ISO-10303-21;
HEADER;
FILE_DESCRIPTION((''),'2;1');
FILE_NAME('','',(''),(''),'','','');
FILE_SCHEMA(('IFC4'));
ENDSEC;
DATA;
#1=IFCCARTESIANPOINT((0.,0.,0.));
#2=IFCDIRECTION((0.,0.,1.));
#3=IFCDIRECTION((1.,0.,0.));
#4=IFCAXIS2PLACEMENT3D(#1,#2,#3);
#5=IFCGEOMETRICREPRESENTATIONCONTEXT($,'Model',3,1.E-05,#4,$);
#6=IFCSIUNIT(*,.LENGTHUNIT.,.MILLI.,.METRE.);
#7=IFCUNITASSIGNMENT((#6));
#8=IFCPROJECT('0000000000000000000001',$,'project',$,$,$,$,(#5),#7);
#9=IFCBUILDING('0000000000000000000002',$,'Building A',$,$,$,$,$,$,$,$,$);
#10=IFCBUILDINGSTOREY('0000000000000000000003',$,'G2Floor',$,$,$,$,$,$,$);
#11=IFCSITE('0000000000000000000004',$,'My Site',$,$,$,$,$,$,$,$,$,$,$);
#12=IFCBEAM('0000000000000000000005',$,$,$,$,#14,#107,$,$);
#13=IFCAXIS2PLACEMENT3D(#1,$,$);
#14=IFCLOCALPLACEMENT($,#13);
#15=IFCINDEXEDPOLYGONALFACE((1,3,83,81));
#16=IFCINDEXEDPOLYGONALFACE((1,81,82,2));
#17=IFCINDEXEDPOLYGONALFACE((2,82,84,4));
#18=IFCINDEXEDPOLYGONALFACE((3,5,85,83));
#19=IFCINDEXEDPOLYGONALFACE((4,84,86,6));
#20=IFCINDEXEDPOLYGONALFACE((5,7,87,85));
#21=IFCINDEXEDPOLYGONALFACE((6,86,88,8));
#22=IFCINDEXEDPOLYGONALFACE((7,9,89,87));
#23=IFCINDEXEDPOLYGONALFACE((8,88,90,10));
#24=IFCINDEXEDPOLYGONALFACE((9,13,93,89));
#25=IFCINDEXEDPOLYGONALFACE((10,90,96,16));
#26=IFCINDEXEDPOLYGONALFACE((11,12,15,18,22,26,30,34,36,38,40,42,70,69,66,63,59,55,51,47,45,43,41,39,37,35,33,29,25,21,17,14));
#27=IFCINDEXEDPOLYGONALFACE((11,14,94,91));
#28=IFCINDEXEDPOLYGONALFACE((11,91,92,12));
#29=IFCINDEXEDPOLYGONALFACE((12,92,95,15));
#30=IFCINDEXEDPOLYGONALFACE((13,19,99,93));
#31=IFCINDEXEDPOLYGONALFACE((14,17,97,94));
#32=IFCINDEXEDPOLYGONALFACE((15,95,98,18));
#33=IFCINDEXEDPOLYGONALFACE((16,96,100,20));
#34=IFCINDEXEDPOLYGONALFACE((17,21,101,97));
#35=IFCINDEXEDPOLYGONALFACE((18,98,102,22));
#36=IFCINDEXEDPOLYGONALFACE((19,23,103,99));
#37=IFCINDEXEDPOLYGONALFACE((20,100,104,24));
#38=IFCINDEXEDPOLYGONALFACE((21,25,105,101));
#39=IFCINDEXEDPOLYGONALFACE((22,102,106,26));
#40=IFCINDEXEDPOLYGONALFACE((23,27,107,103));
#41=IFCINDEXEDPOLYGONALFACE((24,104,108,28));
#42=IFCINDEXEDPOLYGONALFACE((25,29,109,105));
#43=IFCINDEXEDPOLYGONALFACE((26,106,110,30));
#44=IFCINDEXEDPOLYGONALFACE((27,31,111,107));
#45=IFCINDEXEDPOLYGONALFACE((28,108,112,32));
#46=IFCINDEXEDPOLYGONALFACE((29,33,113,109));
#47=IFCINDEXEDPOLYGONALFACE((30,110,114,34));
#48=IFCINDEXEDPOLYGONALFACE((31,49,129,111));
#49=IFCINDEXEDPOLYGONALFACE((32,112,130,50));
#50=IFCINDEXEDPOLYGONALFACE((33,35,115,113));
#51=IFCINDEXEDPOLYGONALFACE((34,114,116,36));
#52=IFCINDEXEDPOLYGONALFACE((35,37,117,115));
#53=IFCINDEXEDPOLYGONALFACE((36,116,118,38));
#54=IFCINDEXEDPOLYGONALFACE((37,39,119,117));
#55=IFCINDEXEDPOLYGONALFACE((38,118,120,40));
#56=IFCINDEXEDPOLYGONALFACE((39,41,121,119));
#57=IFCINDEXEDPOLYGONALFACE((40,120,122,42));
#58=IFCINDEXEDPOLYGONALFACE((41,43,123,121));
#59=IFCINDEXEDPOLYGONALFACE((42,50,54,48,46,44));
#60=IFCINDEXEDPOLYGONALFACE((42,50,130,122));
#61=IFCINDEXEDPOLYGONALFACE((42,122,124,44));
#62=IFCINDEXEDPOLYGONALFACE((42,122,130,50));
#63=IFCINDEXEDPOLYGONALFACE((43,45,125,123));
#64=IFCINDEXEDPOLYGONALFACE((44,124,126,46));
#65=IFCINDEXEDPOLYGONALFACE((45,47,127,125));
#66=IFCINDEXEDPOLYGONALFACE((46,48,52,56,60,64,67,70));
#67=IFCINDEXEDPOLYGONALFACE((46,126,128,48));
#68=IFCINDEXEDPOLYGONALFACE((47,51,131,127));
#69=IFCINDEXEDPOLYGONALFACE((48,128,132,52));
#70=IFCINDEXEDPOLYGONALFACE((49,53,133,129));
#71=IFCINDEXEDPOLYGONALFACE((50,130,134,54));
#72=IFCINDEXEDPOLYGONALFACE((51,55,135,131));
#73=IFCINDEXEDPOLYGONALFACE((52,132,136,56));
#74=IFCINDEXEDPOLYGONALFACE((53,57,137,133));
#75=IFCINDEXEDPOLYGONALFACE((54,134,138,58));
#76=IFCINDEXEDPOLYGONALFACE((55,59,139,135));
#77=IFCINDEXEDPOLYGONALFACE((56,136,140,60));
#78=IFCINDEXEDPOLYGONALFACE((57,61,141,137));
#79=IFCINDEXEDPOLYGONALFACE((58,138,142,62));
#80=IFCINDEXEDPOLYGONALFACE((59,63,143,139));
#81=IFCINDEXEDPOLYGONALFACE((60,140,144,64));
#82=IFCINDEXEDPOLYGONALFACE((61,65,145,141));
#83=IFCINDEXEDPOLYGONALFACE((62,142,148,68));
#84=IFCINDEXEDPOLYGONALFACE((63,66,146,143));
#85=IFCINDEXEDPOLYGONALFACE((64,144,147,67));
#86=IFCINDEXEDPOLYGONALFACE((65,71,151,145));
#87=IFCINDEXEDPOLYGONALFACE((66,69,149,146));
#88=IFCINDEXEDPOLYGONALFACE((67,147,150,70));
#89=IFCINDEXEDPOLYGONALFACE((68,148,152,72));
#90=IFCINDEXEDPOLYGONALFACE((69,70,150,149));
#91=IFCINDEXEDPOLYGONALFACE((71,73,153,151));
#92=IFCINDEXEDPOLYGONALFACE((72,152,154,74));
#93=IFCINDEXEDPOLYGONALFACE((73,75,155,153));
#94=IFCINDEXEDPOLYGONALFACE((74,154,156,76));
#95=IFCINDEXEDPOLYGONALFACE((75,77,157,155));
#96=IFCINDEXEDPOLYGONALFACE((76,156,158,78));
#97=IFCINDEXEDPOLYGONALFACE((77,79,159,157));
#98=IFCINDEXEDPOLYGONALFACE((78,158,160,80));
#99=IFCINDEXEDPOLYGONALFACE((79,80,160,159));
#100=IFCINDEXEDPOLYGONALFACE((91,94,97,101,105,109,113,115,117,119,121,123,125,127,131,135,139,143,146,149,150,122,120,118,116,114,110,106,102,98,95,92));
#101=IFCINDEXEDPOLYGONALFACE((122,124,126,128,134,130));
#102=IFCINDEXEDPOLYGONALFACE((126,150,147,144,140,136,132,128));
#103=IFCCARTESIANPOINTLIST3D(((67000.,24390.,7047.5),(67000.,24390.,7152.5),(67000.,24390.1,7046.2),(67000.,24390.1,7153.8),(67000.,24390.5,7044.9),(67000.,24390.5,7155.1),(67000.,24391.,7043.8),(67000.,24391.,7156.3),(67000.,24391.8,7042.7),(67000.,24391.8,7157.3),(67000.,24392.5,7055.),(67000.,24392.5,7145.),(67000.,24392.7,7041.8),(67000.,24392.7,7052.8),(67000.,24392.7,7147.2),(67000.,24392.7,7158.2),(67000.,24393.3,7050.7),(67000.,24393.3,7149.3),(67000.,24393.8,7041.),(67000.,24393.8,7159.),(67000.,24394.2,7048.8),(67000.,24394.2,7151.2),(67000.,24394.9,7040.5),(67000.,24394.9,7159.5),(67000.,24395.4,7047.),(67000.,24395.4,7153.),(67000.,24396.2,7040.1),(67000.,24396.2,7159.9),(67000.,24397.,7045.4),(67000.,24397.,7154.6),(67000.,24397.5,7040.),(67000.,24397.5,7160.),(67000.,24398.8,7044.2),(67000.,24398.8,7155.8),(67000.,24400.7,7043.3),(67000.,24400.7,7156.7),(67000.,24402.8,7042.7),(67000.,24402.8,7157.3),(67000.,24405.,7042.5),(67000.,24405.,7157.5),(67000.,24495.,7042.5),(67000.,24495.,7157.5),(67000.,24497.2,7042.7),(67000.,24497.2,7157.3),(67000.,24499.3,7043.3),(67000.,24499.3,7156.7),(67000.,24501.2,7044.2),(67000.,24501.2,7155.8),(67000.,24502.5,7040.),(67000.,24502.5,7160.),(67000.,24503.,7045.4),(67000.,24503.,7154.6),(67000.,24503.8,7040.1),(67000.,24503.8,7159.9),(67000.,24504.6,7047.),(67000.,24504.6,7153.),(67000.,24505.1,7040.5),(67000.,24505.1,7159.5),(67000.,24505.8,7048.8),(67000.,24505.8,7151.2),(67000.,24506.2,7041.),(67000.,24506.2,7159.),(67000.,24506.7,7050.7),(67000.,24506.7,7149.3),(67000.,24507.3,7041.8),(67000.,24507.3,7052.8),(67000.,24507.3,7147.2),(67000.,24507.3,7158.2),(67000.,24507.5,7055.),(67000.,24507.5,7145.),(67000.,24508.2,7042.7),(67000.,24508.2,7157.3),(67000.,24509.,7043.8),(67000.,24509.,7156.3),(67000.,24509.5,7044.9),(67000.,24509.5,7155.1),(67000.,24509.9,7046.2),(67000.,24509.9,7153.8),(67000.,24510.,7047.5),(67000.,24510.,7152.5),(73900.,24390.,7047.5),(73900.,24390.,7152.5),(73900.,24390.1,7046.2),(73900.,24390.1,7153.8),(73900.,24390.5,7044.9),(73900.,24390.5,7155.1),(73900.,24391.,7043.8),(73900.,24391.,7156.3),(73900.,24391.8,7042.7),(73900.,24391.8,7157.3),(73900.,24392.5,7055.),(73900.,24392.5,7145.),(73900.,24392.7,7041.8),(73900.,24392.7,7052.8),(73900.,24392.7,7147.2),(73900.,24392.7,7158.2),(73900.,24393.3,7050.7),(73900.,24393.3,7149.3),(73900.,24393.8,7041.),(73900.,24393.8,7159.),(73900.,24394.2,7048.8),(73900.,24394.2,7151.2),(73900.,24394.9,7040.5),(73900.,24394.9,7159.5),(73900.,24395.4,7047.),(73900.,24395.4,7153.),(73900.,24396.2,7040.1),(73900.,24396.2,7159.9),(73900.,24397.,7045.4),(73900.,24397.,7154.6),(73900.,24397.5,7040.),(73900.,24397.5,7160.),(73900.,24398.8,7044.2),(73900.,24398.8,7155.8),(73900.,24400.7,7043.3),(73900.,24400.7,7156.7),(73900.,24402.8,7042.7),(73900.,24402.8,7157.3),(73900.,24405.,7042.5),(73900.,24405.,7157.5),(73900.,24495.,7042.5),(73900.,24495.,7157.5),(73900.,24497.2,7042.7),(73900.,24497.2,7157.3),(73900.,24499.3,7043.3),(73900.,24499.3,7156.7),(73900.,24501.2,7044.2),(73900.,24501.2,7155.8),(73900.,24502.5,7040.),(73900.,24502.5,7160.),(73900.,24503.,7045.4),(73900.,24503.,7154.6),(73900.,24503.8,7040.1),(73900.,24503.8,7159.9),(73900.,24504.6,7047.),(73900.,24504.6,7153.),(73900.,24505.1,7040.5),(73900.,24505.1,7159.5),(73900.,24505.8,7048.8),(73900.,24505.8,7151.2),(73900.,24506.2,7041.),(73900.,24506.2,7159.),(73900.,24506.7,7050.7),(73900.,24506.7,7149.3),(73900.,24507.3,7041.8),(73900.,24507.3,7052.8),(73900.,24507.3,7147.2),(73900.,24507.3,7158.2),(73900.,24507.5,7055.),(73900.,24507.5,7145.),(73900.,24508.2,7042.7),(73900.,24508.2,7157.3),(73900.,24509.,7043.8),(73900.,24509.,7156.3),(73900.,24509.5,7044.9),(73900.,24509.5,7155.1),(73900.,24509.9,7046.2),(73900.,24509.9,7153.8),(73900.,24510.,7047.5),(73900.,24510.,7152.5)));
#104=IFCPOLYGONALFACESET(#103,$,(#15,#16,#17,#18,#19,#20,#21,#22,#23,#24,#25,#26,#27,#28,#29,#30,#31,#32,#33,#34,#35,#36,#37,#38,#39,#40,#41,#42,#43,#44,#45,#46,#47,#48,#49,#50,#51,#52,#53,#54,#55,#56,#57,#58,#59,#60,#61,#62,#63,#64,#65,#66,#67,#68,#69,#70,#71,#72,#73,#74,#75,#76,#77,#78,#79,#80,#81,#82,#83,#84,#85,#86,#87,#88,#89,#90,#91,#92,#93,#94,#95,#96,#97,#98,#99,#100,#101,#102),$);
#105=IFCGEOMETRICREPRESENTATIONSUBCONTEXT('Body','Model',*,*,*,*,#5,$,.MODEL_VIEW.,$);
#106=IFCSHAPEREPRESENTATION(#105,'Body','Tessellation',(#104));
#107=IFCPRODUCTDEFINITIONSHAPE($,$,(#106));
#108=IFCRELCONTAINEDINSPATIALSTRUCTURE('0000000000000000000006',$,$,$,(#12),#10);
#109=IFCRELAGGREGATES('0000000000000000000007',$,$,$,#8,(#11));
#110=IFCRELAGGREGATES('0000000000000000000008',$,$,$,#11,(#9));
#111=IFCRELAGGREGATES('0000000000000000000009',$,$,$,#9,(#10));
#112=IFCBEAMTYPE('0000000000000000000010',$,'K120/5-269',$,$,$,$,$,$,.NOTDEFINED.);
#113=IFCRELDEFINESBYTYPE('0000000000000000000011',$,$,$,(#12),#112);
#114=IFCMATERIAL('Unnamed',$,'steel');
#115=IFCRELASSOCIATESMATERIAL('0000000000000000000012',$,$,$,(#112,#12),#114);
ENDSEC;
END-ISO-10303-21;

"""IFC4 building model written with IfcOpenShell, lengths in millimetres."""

from ifc_helpers import new_model, si_unit, frame, origin_with_axes, place, context, subcontext, project, spatial, polyline, outline, extrude, material, material_profile, profile_set, profile_usage, type_object, element, save


model = new_model("IFC4")

# Units and contexts
model_context = context("Model", 3, precision=1e-05, world=origin_with_axes())
body_context = subcontext(model_context, "Body", "Model", "MODEL_VIEW")
ifc_project = project(units=[si_unit("LENGTHUNIT", "METRE", prefix="MILLI")], contexts=[model_context])

# Site, building, storey
site = spatial("IfcSite", under=ifc_project, Name="My Site")
building = spatial("IfcBuilding", under=site, Name="Building A")
storey = spatial("IfcBuildingStorey", under=building, Name="G2Floor")

# Beam
ifc_material_1 = material(Name="Unnamed", Category="steel")
ifc_material_profile_1 = material_profile(ifc_material_1, outline(polyline([(-52.5, -60.0), (52.5, -60.0), (52.5, -60.0), (53.8, -59.9), (53.8, -59.9), (55.1, -59.5), (55.1, -59.5), (56.2, -59.0), (56.2, -59.0), (57.3, -58.2), (57.3, -58.2), (58.2, -57.3), (58.2, -57.3), (59.0, -56.2), (59.0, -56.2), (59.5, -55.1), (59.5, -55.1), (59.9, -53.8), (59.9, -53.8), (60.0, -52.5), (60.0, -52.5), (60.0, 52.5), (60.0, 52.5), (59.9, 53.8), (59.9, 53.8), (59.5, 55.1), (59.5, 55.1), (59.0, 56.2), (59.0, 56.2), (58.2, 57.3), (58.2, 57.3), (57.3, 58.2), (57.3, 58.2), (56.2, 59.0), (56.2, 59.0), (55.1, 59.5), (55.1, 59.5), (53.8, 59.9), (53.8, 59.9), (52.5, 60.0), (52.5, 60.0), (-52.5, 60.0), (-52.5, 60.0), (-53.8, 59.9), (-53.8, 59.9), (-55.1, 59.5), (-55.1, 59.5), (-56.2, 59.0), (-56.2, 59.0), (-57.3, 58.2), (-57.3, 58.2), (-58.2, 57.3), (-58.2, 57.3), (-59.0, 56.2), (-59.0, 56.2), (-59.5, 55.1), (-59.5, 55.1), (-59.9, 53.8), (-59.9, 53.8), (-60.0, 52.5), (-60.0, 52.5), (-60.0, -52.5), (-60.0, -52.5), (-59.9, -53.8), (-59.9, -53.8), (-59.5, -55.1), (-59.5, -55.1), (-59.0, -56.2), (-59.0, -56.2), (-58.2, -57.3), (-58.2, -57.3), (-57.3, -58.2), (-57.3, -58.2), (-56.2, -59.0), (-56.2, -59.0), (-55.1, -59.5), (-55.1, -59.5), (-53.8, -59.9), (-53.8, -59.9), (-52.5, -60.0), (-52.5, -60.0), (-45.0, -57.5), (-45.0, -57.5), (45.0, -57.5), (45.0, -57.5), (47.2, -57.3), (47.2, -57.3), (49.3, -56.7), (49.3, -56.7), (51.2, -55.8), (51.2, -55.8), (53.0, -54.6), (53.0, -54.6), (54.6, -53.0), (54.6, -53.0), (55.8, -51.2), (55.8, -51.2), (56.7, -49.3), (56.7, -49.3), (57.3, -47.2), (57.3, -47.2), (57.5, -45.0), (57.5, -45.0), (57.5, 45.0), (57.5, 45.0), (57.3, 47.2), (57.3, 47.2), (56.7, 49.3), (56.7, 49.3), (55.8, 51.2), (55.8, 51.2), (54.6, 53.0), (54.6, 53.0), (53.0, 54.6), (53.0, 54.6), (51.2, 55.8), (51.2, 55.8), (49.3, 56.7), (49.3, 56.7), (47.2, 57.3), (47.2, 57.3), (45.0, 57.5), (45.0, 57.5), (-45.0, 57.5), (-45.0, 57.5), (-47.2, 57.3), (-47.2, 57.3), (-49.3, 56.7), (-49.3, 56.7), (-51.2, 55.8), (-51.2, 55.8), (-53.0, 54.6), (-53.0, 54.6), (-54.6, 53.0), (-54.6, 53.0), (-55.8, 51.2), (-55.8, 51.2), (-56.7, 49.3), (-56.7, 49.3), (-57.3, 47.2), (-57.3, 47.2), (-57.5, 45.0), (-57.5, 45.0), (-57.5, -45.0), (-57.5, -45.0), (-57.3, -47.2), (-57.3, -47.2), (-56.7, -49.3), (-56.7, -49.3), (-55.8, -51.2), (-55.8, -51.2), (-54.6, -53.0), (-54.6, -53.0), (-53.0, -54.6), (-53.0, -54.6), (-51.2, -55.8), (-51.2, -55.8), (-49.3, -56.7), (-49.3, -56.7), (-47.2, -57.3), (-47.2, -57.3), (-45.0, -57.5), (-45.0, -57.5), (-52.5, -60.0)])))
ifc_profile_set_1 = profile_set([ifc_material_profile_1], Name="K120/5-269")
ifc_profile_usage_1 = profile_usage(ifc_profile_set_1)
beam_type_1 = type_object("IfcBeamType", Name="K120/5-269", PredefinedType="NOTDEFINED", material=ifc_profile_set_1)
beam_1_placement = place(None, frame((67000.0, 24450.0, 7100.0), z_axis=(1.0, 0.0, 0.0), x_axis=(0.0, -1.0, 0.0)))
element("IfcBeam", 1, at=beam_1_placement, inside=storey, type_object=beam_type_1, material=ifc_profile_usage_1, context=body_context, shape_type="SweptSolid", body=[
    extrude(outline(polyline([(-52.5, -60.0), (52.5, -60.0), (52.5, -60.0), (53.8, -59.9), (53.8, -59.9), (55.1, -59.5), (55.1, -59.5), (56.2, -59.0), (56.2, -59.0), (57.3, -58.2), (57.3, -58.2), (58.2, -57.3), (58.2, -57.3), (59.0, -56.2), (59.0, -56.2), (59.5, -55.1), (59.5, -55.1), (59.9, -53.8), (59.9, -53.8), (60.0, -52.5), (60.0, -52.5), (60.0, 52.5), (60.0, 52.5), (59.9, 53.8), (59.9, 53.8), (59.5, 55.1), (59.5, 55.1), (59.0, 56.2), (59.0, 56.2), (58.2, 57.3), (58.2, 57.3), (57.3, 58.2), (57.3, 58.2), (56.2, 59.0), (56.2, 59.0), (55.1, 59.5), (55.1, 59.5), (53.8, 59.9), (53.8, 59.9), (52.5, 60.0), (52.5, 60.0), (-52.5, 60.0), (-52.5, 60.0), (-53.8, 59.9), (-53.8, 59.9), (-55.1, 59.5), (-55.1, 59.5), (-56.2, 59.0), (-56.2, 59.0), (-57.3, 58.2), (-57.3, 58.2), (-58.2, 57.3), (-58.2, 57.3), (-59.0, 56.2), (-59.0, 56.2), (-59.5, 55.1), (-59.5, 55.1), (-59.9, 53.8), (-59.9, 53.8), (-60.0, 52.5), (-60.0, 52.5), (-60.0, -52.5), (-60.0, -52.5), (-59.9, -53.8), (-59.9, -53.8), (-59.5, -55.1), (-59.5, -55.1), (-59.0, -56.2), (-59.0, -56.2), (-58.2, -57.3), (-58.2, -57.3), (-57.3, -58.2), (-57.3, -58.2), (-56.2, -59.0), (-56.2, -59.0), (-55.1, -59.5), (-55.1, -59.5), (-53.8, -59.9), (-53.8, -59.9), (-52.5, -60.0), (-52.5, -60.0), (-45.0, -57.5), (-45.0, -57.5), (45.0, -57.5), (45.0, -57.5), (47.2, -57.3), (47.2, -57.3), (49.3, -56.7), (49.3, -56.7), (51.2, -55.8), (51.2, -55.8), (53.0, -54.6), (53.0, -54.6), (54.6, -53.0), (54.6, -53.0), (55.8, -51.2), (55.8, -51.2), (56.7, -49.3), (56.7, -49.3), (57.3, -47.2), (57.3, -47.2), (57.5, -45.0), (57.5, -45.0), (57.5, 45.0), (57.5, 45.0), (57.3, 47.2), (57.3, 47.2), (56.7, 49.3), (56.7, 49.3), (55.8, 51.2), (55.8, 51.2), (54.6, 53.0), (54.6, 53.0), (53.0, 54.6), (53.0, 54.6), (51.2, 55.8), (51.2, 55.8), (49.3, 56.7), (49.3, 56.7), (47.2, 57.3), (47.2, 57.3), (45.0, 57.5), (45.0, 57.5), (-45.0, 57.5), (-45.0, 57.5), (-47.2, 57.3), (-47.2, 57.3), (-49.3, 56.7), (-49.3, 56.7), (-51.2, 55.8), (-51.2, 55.8), (-53.0, 54.6), (-53.0, 54.6), (-54.6, 53.0), (-54.6, 53.0), (-55.8, 51.2), (-55.8, 51.2), (-56.7, 49.3), (-56.7, 49.3), (-57.3, 47.2), (-57.3, 47.2), (-57.5, 45.0), (-57.5, 45.0), (-57.5, -45.0), (-57.5, -45.0), (-57.3, -47.2), (-57.3, -47.2), (-56.7, -49.3), (-56.7, -49.3), (-55.8, -51.2), (-55.8, -51.2), (-54.6, -53.0), (-54.6, -53.0), (-53.0, -54.6), (-53.0, -54.6), (-51.2, -55.8), (-51.2, -55.8), (-49.3, -56.7), (-49.3, -56.7), (-47.2, -57.3), (-47.2, -57.3), (-45.0, -57.5), (-45.0, -57.5), (-52.5, -60.0)])), origin_with_axes(), (0.0, 0.0, 1.0), 6900.0),
])

save(model, "model.ifc")
